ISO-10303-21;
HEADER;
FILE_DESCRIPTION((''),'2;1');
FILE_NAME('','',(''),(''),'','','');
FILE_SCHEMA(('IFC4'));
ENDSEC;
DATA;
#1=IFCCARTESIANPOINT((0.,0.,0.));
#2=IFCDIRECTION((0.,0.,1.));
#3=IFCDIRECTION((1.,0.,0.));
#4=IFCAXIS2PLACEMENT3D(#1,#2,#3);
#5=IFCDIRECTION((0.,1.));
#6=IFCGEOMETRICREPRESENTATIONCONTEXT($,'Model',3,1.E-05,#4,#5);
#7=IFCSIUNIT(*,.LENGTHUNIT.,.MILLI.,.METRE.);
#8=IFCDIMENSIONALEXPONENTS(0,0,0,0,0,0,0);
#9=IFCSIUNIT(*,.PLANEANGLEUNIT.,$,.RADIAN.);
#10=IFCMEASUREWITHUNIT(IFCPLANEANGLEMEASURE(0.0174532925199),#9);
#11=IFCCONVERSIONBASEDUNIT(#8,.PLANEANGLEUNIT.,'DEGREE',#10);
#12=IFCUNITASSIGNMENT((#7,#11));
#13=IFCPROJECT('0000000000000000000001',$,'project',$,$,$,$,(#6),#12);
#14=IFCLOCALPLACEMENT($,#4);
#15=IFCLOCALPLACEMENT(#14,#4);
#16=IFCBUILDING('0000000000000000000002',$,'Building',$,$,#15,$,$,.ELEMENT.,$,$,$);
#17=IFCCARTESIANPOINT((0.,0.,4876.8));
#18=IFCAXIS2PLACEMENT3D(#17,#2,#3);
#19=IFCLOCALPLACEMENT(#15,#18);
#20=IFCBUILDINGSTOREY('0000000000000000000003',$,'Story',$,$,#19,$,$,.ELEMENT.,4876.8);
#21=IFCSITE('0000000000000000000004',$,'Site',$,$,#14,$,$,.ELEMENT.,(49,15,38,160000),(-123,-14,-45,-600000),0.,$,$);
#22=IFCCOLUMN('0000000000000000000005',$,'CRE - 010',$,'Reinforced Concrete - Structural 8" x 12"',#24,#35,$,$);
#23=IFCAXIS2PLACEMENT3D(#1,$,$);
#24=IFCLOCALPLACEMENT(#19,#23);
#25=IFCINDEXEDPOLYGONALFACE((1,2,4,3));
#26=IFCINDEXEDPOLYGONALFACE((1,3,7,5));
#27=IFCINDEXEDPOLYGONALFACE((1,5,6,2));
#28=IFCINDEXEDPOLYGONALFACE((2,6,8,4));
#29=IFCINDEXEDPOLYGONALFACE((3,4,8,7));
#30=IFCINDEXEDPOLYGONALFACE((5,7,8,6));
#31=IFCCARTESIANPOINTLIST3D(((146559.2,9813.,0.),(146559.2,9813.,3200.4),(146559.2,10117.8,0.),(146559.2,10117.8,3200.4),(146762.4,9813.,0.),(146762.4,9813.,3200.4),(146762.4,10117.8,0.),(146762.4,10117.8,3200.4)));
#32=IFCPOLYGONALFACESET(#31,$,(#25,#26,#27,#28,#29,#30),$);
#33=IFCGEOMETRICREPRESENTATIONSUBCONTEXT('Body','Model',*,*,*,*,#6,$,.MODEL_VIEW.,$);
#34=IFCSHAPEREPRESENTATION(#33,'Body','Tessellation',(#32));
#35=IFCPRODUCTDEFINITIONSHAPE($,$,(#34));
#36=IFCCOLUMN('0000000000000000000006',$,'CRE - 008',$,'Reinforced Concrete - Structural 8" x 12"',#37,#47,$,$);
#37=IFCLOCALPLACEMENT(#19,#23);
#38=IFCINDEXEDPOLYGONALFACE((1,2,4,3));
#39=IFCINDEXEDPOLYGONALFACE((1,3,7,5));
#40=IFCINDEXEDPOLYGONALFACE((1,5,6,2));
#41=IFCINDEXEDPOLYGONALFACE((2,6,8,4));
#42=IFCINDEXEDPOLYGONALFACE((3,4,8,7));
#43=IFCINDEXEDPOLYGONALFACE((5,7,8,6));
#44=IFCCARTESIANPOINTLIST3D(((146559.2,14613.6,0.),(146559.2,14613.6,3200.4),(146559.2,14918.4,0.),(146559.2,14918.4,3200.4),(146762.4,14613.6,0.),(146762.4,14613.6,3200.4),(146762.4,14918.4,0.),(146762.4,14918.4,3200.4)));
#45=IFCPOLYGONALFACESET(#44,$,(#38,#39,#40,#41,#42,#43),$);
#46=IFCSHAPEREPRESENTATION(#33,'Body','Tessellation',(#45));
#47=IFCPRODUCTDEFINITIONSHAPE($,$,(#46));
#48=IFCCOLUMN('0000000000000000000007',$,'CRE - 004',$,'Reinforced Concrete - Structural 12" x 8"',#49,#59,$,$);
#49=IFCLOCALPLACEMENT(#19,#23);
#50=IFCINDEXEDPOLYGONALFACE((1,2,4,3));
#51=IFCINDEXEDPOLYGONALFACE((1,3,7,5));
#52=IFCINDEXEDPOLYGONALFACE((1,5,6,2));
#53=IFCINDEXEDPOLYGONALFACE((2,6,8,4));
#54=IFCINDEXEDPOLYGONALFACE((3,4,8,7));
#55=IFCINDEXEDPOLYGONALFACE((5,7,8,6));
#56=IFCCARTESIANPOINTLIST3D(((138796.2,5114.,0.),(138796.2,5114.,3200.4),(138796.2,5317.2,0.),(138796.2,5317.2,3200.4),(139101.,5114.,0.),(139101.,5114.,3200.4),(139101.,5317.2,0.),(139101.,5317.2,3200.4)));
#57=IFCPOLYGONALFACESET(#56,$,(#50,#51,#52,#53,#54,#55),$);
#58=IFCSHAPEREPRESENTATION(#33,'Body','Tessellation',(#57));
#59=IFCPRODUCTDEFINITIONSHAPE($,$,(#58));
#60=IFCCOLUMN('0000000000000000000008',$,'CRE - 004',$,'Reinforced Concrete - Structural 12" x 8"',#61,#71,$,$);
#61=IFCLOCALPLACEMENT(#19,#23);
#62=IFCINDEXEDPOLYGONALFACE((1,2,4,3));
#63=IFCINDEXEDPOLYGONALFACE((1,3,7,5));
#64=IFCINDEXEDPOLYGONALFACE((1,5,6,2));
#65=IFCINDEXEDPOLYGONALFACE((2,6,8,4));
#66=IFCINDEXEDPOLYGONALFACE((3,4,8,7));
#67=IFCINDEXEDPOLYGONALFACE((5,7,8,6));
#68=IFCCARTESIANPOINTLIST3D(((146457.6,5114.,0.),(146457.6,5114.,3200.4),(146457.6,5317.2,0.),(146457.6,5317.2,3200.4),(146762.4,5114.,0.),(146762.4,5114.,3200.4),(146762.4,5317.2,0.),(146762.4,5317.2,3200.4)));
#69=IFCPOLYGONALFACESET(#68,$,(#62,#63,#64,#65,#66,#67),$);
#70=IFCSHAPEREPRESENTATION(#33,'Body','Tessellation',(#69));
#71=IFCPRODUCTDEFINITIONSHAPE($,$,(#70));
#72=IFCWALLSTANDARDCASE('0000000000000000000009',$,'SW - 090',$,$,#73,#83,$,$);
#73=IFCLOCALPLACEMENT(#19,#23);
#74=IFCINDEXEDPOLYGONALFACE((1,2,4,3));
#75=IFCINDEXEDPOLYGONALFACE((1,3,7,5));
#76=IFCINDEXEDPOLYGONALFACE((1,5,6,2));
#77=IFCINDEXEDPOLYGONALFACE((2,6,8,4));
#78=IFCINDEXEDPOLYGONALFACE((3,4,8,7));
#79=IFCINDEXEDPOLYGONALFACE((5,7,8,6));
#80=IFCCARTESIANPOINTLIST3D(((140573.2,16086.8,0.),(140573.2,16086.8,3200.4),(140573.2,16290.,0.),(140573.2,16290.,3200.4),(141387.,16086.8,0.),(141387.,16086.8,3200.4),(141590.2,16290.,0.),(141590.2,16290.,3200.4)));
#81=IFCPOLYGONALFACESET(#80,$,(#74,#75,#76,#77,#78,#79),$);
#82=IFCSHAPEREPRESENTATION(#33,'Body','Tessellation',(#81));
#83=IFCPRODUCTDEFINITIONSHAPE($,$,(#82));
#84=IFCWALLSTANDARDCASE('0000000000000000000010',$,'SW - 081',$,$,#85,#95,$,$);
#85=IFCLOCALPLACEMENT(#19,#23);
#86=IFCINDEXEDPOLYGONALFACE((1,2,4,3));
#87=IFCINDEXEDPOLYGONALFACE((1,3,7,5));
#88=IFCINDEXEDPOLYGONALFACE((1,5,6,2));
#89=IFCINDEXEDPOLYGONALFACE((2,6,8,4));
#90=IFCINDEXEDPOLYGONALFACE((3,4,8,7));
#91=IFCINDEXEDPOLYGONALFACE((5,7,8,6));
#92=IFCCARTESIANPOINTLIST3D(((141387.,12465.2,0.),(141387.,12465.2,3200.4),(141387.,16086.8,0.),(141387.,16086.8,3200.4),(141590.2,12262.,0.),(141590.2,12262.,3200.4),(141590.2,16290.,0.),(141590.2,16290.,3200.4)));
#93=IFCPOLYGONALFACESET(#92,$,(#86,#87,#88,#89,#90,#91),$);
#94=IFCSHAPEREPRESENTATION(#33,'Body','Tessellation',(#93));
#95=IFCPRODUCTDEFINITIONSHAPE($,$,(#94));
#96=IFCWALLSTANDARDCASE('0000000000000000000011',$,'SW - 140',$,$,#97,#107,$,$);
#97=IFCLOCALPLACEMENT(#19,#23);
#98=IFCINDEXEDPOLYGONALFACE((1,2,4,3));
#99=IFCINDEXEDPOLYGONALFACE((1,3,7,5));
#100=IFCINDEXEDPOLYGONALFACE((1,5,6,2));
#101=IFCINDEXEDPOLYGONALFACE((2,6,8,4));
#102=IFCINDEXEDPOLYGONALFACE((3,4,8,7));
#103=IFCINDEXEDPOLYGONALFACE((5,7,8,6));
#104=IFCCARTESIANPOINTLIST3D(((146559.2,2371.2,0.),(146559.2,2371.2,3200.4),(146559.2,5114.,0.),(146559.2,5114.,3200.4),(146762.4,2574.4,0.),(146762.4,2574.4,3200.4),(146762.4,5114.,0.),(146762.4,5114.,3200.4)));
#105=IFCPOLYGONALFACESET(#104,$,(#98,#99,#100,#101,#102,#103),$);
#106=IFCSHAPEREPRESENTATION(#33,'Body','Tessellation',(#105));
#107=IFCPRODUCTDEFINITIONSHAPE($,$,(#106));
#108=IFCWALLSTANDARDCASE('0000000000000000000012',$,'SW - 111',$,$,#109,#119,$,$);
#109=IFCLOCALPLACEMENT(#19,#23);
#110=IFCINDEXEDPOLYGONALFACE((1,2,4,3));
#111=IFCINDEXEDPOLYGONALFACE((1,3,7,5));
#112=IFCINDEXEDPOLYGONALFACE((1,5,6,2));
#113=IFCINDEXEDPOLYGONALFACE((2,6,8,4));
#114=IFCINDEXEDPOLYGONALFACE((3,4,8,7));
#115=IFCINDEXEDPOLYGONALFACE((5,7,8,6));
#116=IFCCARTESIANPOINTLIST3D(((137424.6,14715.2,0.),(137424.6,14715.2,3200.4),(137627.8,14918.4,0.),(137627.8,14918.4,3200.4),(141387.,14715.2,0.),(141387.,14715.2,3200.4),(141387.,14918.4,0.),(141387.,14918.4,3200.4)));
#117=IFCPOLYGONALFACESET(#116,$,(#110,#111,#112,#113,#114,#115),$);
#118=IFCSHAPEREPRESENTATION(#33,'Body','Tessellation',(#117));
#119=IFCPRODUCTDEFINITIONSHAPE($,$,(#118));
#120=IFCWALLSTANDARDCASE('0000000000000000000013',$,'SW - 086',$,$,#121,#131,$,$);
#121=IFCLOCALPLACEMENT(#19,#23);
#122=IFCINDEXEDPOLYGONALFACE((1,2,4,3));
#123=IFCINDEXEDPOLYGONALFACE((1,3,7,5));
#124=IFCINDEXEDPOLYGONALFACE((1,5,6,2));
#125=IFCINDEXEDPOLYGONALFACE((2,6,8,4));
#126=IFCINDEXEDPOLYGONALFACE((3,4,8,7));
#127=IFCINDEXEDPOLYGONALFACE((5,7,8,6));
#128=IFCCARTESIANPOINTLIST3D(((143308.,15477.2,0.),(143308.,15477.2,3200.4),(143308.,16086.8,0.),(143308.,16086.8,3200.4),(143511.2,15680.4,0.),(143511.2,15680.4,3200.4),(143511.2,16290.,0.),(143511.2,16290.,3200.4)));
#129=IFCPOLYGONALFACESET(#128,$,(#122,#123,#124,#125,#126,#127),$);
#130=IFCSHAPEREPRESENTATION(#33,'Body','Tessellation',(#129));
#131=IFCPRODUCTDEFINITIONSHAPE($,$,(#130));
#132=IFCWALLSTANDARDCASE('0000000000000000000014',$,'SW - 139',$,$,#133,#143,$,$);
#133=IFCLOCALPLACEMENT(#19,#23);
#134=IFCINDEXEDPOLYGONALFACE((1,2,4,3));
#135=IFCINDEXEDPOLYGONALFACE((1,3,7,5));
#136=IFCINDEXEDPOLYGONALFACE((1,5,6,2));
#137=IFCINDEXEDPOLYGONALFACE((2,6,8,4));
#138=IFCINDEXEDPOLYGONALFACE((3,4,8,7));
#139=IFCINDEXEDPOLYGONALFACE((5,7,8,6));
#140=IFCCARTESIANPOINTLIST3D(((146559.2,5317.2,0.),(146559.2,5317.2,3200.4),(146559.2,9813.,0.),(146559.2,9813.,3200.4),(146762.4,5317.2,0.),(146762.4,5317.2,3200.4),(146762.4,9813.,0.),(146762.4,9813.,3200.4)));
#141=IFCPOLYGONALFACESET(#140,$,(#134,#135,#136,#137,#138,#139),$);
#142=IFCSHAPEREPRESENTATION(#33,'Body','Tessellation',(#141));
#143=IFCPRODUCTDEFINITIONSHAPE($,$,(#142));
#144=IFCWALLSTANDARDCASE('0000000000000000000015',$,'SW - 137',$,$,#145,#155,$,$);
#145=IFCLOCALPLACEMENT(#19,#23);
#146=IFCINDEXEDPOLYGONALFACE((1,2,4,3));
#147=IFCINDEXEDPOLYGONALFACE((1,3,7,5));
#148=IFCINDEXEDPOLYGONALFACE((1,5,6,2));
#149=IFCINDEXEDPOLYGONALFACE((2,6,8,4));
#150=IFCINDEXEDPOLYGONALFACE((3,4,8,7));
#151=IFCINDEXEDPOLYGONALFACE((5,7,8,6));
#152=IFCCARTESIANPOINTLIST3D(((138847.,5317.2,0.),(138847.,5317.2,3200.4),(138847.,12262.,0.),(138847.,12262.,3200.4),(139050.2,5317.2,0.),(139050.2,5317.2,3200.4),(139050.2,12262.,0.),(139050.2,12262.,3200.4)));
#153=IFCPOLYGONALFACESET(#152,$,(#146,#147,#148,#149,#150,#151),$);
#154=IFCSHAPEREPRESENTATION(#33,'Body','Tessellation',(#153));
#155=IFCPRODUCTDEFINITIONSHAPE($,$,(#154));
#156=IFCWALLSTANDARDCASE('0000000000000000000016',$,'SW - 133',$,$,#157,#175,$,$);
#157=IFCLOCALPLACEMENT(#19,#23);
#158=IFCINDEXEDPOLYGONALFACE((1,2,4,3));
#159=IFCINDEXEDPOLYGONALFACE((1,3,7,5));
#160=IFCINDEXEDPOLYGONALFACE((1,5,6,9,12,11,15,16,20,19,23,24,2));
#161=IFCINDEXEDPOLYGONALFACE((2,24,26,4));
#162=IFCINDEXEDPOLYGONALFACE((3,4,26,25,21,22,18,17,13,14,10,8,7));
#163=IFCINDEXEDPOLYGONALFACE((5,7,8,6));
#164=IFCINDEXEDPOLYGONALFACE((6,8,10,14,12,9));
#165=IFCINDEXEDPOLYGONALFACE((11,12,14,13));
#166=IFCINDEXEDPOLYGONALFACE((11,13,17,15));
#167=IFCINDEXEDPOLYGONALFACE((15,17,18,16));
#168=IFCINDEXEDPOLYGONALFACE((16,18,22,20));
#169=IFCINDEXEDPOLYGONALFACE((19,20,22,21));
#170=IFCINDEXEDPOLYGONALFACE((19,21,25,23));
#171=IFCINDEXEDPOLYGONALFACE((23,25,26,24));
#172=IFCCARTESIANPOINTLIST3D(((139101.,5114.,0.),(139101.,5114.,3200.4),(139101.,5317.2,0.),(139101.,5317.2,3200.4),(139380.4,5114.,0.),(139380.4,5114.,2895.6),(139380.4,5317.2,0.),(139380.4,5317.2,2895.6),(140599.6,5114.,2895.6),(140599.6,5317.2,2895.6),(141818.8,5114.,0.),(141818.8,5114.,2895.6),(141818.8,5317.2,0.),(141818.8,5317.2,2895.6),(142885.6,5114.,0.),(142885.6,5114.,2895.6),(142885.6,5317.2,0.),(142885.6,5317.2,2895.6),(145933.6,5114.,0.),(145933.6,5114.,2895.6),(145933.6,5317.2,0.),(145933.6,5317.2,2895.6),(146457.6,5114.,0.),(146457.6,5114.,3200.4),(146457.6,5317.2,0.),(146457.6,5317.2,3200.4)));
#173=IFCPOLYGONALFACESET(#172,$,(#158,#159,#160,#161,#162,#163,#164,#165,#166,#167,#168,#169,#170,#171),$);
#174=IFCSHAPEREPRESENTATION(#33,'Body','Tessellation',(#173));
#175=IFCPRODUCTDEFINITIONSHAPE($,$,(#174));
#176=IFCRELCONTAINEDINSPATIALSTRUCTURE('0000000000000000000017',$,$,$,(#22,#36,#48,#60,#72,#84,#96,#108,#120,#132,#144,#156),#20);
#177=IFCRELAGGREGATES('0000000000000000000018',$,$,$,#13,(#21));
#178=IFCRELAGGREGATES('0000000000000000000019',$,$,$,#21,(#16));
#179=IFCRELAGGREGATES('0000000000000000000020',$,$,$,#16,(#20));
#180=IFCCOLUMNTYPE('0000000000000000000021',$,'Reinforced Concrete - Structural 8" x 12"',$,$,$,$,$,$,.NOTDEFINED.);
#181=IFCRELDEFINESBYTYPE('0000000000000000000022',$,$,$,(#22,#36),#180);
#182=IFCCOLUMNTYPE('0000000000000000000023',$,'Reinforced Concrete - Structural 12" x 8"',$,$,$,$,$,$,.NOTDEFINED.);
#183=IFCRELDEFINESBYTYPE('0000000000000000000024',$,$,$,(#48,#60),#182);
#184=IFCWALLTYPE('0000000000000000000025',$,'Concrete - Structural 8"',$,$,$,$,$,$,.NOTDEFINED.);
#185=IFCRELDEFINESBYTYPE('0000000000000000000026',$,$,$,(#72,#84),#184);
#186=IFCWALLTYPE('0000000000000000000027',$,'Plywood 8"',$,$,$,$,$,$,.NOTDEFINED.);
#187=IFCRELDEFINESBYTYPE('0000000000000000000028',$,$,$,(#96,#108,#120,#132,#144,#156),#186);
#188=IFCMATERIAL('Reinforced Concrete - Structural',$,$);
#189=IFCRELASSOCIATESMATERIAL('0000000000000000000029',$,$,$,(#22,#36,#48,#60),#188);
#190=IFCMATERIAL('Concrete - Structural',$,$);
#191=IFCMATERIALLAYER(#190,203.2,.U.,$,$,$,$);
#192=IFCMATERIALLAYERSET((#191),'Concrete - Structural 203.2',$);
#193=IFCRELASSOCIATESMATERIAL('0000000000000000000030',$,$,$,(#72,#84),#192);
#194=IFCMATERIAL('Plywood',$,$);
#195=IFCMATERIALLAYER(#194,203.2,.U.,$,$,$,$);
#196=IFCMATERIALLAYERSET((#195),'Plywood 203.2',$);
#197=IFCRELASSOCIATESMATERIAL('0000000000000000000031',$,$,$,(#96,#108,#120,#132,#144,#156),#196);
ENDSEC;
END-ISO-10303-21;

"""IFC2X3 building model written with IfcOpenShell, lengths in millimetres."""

from ifc_helpers import new_model, entity, si_unit, converted_unit, direction, frame, origin_with_axes, origin_2d_with_axis, place, context, subcontext, project, spatial, polyline, rectangle, outline, extrude, material, layer, layer_set, layer_usage, type_object, element, save


model = new_model("IFC2X3")

# Units and contexts
model_context = context("Model", 3, precision=1e-05, world=origin_with_axes(), true_north=direction((0.0, 1.0)))
body_context = subcontext(model_context, "Body", "Model", "MODEL_VIEW")
ifc_project = project(units=[si_unit("LENGTHUNIT", "METRE", prefix="MILLI"), converted_unit("PLANEANGLEUNIT", "DEGREE", entity("IfcPlaneAngleMeasure", 0.0174532925199), si_unit("PLANEANGLEUNIT", "RADIAN"), dimensions=[0, 0, 0, 0, 0, 0, 0])], contexts=[model_context])

# Site, building, storey
site_placement = place(None, origin_with_axes())
site = spatial("IfcSite", under=ifc_project, at=site_placement, Name="Site", CompositionType="ELEMENT", RefLatitude=(49, 15, 38, 160000), RefLongitude=(-123, -14, -45, -600000), RefElevation=0.0)
building_placement = place(site_placement, origin_with_axes())
building = spatial("IfcBuilding", under=site, at=building_placement, Name="Building", CompositionType="ELEMENT")
storey_placement = place(building_placement, frame((0.0, 0.0, 4876.8), z_axis=(0.0, 0.0, 1.0), x_axis=(1.0, 0.0, 0.0)))
storey = spatial("IfcBuildingStorey", under=building, at=storey_placement, Name="Story", CompositionType="ELEMENT", Elevation=4876.8)

# Columns
ifc_material_1 = material(Name="Reinforced Concrete - Structural")
column_type_1 = type_object("IfcColumnType", Name="Reinforced Concrete - Structural 8\" x 12\"", PredefinedType="NOTDEFINED")
for number, where, z_axis, x_axis, name in (
    (1, (146660.8, 9965.4, 0.0), (0.0, 0.0, 1.0), (1.0, 0.0, 0.0), "CRE - 010"),
    (2, (146660.8, 14766.0, 0.0), (0.0, 0.0, 1.0), (1.0, 0.0, 0.0), "CRE - 008"),
):
    element("IfcColumn", number, at=place(storey_placement, frame(where, z_axis=z_axis, x_axis=x_axis)), inside=storey, type_object=column_type_1, material=ifc_material_1, Name=name, ObjectType="Reinforced Concrete - Structural 8\" x 12\"", context=body_context, shape_type="SweptSolid", body=[
        extrude(rectangle(XDim=203.2, YDim=304.8, at=origin_2d_with_axis()), origin_with_axes(), (0.0, 0.0, 1.0), 3200.4),
    ])
column_type_2 = type_object("IfcColumnType", Name="Reinforced Concrete - Structural 12\" x 8\"", PredefinedType="NOTDEFINED")
for number, where, z_axis, x_axis, name in (
    (3, (138948.6, 5215.6, 0.0), (0.0, 0.0, 1.0), (1.0, 0.0, 0.0), "CRE - 004"),
    (4, (146610.0, 5215.6, 0.0), (0.0, 0.0, 1.0), (1.0, 0.0, 0.0), "CRE - 004"),
):
    element("IfcColumn", number, at=place(storey_placement, frame(where, z_axis=z_axis, x_axis=x_axis)), inside=storey, type_object=column_type_2, material=ifc_material_1, Name=name, ObjectType="Reinforced Concrete - Structural 12\" x 8\"", context=body_context, shape_type="SweptSolid", body=[
        extrude(rectangle(XDim=304.8, YDim=203.2, at=origin_2d_with_axis()), origin_with_axes(), (0.0, 0.0, 1.0), 3200.4),
    ])

# Walls
ifc_material_2 = material(Name="Concrete - Structural")
ifc_layer_1 = layer(ifc_material_2, 203.2, ventilated="UNKNOWN")
ifc_layer_set_1 = layer_set([ifc_layer_1], Name="Concrete - Structural 203.2")
ifc_layer_usage_1 = layer_usage(ifc_layer_set_1, "AXIS2", "NEGATIVE", 0.0)
wall_type_1 = type_object("IfcWallType", Name="Concrete - Structural 8\"", PredefinedType="NOTDEFINED")
wall_1_placement = place(storey_placement, frame((141387.0, 16086.8, 0.0), z_axis=(0.0, 0.0, 1.0), x_axis=(-1.0, 0.0, 0.0)))
element("IfcWallStandardCase", 5, at=wall_1_placement, inside=storey, type_object=wall_type_1, material=ifc_layer_usage_1, Name="SW - 090", context=body_context, shape_type="SweptSolid", body=[
    extrude(outline(polyline([(-203.2, -203.2), (813.8, -203.2), (813.8, 0.0), (0.0, 0.0), (-203.2, -203.2)])), origin_with_axes(), (0.0, 0.0, 1.0), 3200.4),
])
ifc_layer_usage_2 = layer_usage(ifc_layer_set_1, "AXIS2", "NEGATIVE", 0.0)
wall_2_placement = place(storey_placement, frame((141387.0, 12465.2, 0.0), z_axis=(0.0, 0.0, 1.0), x_axis=(0.0, 1.0, 0.0)))
element("IfcWallStandardCase", 6, at=wall_2_placement, inside=storey, type_object=wall_type_1, material=ifc_layer_usage_2, Name="SW - 081", context=body_context, shape_type="SweptSolid", body=[
    extrude(outline(polyline([(-203.2, -203.2), (3824.8, -203.2), (3621.6, 0.0), (0.0, 0.0), (-203.2, -203.2)])), origin_with_axes(), (0.0, 0.0, 1.0), 3200.4),
])
ifc_material_3 = material(Name="Plywood")
ifc_layer_2 = layer(ifc_material_3, 203.2, ventilated="UNKNOWN")
ifc_layer_set_2 = layer_set([ifc_layer_2], Name="Plywood 203.2")
ifc_layer_usage_3 = layer_usage(ifc_layer_set_2, "AXIS2", "NEGATIVE", 0.0)
wall_type_2 = type_object("IfcWallType", Name="Plywood 8\"", PredefinedType="NOTDEFINED")
wall_3_placement = place(storey_placement, frame((146762.4, 5114.0, 0.0), z_axis=(0.0, 0.0, 1.0), x_axis=(0.0, -1.0, 0.0)))
element("IfcWallStandardCase", 7, at=wall_3_placement, inside=storey, type_object=wall_type_2, material=ifc_layer_usage_3, Name="SW - 140", context=body_context, shape_type="SweptSolid", body=[
    extrude(outline(polyline([(0.0, -203.2), (2742.9, -203.2), (2539.7, 0.0), (0.0, 0.0), (0.0, -203.2)])), origin_with_axes(), (0.0, 0.0, 1.0), 3200.4),
])
ifc_layer_usage_4 = layer_usage(ifc_layer_set_2, "AXIS2", "POSITIVE", 0.0)
wall_4_placement = place(storey_placement, frame((141387.0, 14918.4, 0.0), z_axis=(0.0, 0.0, 1.0), x_axis=(-1.0, 0.0, 0.0)))
element("IfcWallStandardCase", 8, at=wall_4_placement, inside=storey, type_object=wall_type_2, material=ifc_layer_usage_4, Name="SW - 111", context=body_context, shape_type="SweptSolid", body=[
    extrude(outline(polyline([(0.0, 0.0), (3759.2, 0.0), (3962.4, 203.2), (0.0, 203.2), (0.0, 0.0)])), origin_with_axes(), (0.0, 0.0, 1.0), 3200.4),
])
ifc_layer_usage_5 = layer_usage(ifc_layer_set_2, "AXIS2", "NEGATIVE", 0.0)
wall_5_placement = place(storey_placement, frame((143308.0, 15477.2, 0.0), z_axis=(0.0, 0.0, 1.0), x_axis=(0.0, 1.0, 0.0)))
element("IfcWallStandardCase", 9, at=wall_5_placement, inside=storey, type_object=wall_type_2, material=ifc_layer_usage_5, Name="SW - 086", context=body_context, shape_type="SweptSolid", body=[
    extrude(outline(polyline([(203.2, -203.2), (812.8, -203.2), (609.6, 0.0), (0.0, 0.0), (203.2, -203.2)])), origin_with_axes(), (0.0, 0.0, 1.0), 3200.4),
])
ifc_layer_usage_6 = layer_usage(ifc_layer_set_2, "AXIS2", "NEGATIVE", 0.0)
wall_6_placement = place(storey_placement, frame((146762.4, 9813.0, 0.0), z_axis=(0.0, 0.0, 1.0), x_axis=(0.0, -1.0, 0.0)))
element("IfcWallStandardCase", 10, at=wall_6_placement, inside=storey, type_object=wall_type_2, material=ifc_layer_usage_6, Name="SW - 139", context=body_context, shape_type="SweptSolid", body=[
    extrude(outline(polyline([(0.0, -203.2), (4495.8, -203.2), (4495.8, 0.0), (0.0, 0.0), (0.0, -203.2)])), origin_with_axes(), (0.0, 0.0, 1.0), 3200.4),
])
ifc_layer_usage_7 = layer_usage(ifc_layer_set_2, "AXIS2", "POSITIVE", 0.0)
wall_7_placement = place(storey_placement, frame((139050.2, 5317.2, 0.0), z_axis=(0.0, 0.0, 1.0), x_axis=(0.0, 1.0, 0.0)))
element("IfcWallStandardCase", 11, at=wall_7_placement, inside=storey, type_object=wall_type_2, material=ifc_layer_usage_7, Name="SW - 137", context=body_context, shape_type="SweptSolid", body=[
    extrude(outline(polyline([(0.0, 0.0), (6944.8, 0.0), (6944.8, 203.2), (0.0, 203.2), (0.0, 0.0)])), origin_with_axes(), (0.0, 0.0, 1.0), 3200.4),
])

# Wall, openings
ifc_layer_usage_8 = layer_usage(ifc_layer_set_2, "AXIS2", "POSITIVE", 0.0)
wall_8_placement = place(storey_placement, frame((146457.6, 5317.2, 0.0), z_axis=(0.0, 0.0, 1.0), x_axis=(-1.0, 0.0, 0.0)))
wall_8 = element("IfcWallStandardCase", 12, at=wall_8_placement, inside=storey, type_object=wall_type_2, material=ifc_layer_usage_8, Name="SW - 133", context=body_context, shape_type="SweptSolid", body=[
    extrude(outline(polyline([(0.0, 0.0), (7356.6, 0.0), (7356.6, 203.2), (0.0, 203.2), (0.0, 0.0)])), origin_with_axes(), (0.0, 0.0, 1.0), 3200.4),
])
opening_1_placement = place(wall_8_placement, frame((5248.4, 0.0, 0.0), z_axis=(0.0, 0.0, 1.0), x_axis=(1.0, 0.0, 0.0)))
element("IfcOpeningElement", 13, at=opening_1_placement, cuts=wall_8, context=body_context, shape_type="SweptSolid", body=[
    extrude(rectangle(XDim=1219.2, YDim=2895.6, at=origin_2d_with_axis()), frame((0.0, -203.2, 1447.8), z_axis=(0.0, 1.0, 0.0), x_axis=(1.0, 0.0, 0.0)), (0.0, 0.0, 1.0), 609.6),
])
opening_2_placement = place(wall_8_placement, frame((6467.6, 0.0, 0.0), z_axis=(0.0, 0.0, 1.0), x_axis=(1.0, 0.0, 0.0)))
element("IfcOpeningElement", 14, at=opening_2_placement, cuts=wall_8, context=body_context, shape_type="SweptSolid", body=[
    extrude(rectangle(XDim=1219.2, YDim=2895.6, at=origin_2d_with_axis()), frame((0.0, -203.2, 1447.8), z_axis=(0.0, -1.0, 0.0), x_axis=(-1.0, 0.0, 0.0)), (0.0, 0.0, -1.0), 609.6),
])
opening_3_placement = place(wall_8_placement, frame((2048.0, 0.0, 0.0), z_axis=(0.0, 0.0, 1.0), x_axis=(1.0, 0.0, 0.0)))
element("IfcOpeningElement", 15, at=opening_3_placement, cuts=wall_8, context=body_context, shape_type="SweptSolid", body=[
    extrude(rectangle(XDim=3048.0, YDim=2895.6, at=origin_2d_with_axis()), frame((0.0, -203.2, 1447.8), z_axis=(0.0, -1.0, 0.0), x_axis=(-1.0, 0.0, 0.0)), (0.0, 0.0, -1.0), 609.6),
])

save(model, "model.ifc")
